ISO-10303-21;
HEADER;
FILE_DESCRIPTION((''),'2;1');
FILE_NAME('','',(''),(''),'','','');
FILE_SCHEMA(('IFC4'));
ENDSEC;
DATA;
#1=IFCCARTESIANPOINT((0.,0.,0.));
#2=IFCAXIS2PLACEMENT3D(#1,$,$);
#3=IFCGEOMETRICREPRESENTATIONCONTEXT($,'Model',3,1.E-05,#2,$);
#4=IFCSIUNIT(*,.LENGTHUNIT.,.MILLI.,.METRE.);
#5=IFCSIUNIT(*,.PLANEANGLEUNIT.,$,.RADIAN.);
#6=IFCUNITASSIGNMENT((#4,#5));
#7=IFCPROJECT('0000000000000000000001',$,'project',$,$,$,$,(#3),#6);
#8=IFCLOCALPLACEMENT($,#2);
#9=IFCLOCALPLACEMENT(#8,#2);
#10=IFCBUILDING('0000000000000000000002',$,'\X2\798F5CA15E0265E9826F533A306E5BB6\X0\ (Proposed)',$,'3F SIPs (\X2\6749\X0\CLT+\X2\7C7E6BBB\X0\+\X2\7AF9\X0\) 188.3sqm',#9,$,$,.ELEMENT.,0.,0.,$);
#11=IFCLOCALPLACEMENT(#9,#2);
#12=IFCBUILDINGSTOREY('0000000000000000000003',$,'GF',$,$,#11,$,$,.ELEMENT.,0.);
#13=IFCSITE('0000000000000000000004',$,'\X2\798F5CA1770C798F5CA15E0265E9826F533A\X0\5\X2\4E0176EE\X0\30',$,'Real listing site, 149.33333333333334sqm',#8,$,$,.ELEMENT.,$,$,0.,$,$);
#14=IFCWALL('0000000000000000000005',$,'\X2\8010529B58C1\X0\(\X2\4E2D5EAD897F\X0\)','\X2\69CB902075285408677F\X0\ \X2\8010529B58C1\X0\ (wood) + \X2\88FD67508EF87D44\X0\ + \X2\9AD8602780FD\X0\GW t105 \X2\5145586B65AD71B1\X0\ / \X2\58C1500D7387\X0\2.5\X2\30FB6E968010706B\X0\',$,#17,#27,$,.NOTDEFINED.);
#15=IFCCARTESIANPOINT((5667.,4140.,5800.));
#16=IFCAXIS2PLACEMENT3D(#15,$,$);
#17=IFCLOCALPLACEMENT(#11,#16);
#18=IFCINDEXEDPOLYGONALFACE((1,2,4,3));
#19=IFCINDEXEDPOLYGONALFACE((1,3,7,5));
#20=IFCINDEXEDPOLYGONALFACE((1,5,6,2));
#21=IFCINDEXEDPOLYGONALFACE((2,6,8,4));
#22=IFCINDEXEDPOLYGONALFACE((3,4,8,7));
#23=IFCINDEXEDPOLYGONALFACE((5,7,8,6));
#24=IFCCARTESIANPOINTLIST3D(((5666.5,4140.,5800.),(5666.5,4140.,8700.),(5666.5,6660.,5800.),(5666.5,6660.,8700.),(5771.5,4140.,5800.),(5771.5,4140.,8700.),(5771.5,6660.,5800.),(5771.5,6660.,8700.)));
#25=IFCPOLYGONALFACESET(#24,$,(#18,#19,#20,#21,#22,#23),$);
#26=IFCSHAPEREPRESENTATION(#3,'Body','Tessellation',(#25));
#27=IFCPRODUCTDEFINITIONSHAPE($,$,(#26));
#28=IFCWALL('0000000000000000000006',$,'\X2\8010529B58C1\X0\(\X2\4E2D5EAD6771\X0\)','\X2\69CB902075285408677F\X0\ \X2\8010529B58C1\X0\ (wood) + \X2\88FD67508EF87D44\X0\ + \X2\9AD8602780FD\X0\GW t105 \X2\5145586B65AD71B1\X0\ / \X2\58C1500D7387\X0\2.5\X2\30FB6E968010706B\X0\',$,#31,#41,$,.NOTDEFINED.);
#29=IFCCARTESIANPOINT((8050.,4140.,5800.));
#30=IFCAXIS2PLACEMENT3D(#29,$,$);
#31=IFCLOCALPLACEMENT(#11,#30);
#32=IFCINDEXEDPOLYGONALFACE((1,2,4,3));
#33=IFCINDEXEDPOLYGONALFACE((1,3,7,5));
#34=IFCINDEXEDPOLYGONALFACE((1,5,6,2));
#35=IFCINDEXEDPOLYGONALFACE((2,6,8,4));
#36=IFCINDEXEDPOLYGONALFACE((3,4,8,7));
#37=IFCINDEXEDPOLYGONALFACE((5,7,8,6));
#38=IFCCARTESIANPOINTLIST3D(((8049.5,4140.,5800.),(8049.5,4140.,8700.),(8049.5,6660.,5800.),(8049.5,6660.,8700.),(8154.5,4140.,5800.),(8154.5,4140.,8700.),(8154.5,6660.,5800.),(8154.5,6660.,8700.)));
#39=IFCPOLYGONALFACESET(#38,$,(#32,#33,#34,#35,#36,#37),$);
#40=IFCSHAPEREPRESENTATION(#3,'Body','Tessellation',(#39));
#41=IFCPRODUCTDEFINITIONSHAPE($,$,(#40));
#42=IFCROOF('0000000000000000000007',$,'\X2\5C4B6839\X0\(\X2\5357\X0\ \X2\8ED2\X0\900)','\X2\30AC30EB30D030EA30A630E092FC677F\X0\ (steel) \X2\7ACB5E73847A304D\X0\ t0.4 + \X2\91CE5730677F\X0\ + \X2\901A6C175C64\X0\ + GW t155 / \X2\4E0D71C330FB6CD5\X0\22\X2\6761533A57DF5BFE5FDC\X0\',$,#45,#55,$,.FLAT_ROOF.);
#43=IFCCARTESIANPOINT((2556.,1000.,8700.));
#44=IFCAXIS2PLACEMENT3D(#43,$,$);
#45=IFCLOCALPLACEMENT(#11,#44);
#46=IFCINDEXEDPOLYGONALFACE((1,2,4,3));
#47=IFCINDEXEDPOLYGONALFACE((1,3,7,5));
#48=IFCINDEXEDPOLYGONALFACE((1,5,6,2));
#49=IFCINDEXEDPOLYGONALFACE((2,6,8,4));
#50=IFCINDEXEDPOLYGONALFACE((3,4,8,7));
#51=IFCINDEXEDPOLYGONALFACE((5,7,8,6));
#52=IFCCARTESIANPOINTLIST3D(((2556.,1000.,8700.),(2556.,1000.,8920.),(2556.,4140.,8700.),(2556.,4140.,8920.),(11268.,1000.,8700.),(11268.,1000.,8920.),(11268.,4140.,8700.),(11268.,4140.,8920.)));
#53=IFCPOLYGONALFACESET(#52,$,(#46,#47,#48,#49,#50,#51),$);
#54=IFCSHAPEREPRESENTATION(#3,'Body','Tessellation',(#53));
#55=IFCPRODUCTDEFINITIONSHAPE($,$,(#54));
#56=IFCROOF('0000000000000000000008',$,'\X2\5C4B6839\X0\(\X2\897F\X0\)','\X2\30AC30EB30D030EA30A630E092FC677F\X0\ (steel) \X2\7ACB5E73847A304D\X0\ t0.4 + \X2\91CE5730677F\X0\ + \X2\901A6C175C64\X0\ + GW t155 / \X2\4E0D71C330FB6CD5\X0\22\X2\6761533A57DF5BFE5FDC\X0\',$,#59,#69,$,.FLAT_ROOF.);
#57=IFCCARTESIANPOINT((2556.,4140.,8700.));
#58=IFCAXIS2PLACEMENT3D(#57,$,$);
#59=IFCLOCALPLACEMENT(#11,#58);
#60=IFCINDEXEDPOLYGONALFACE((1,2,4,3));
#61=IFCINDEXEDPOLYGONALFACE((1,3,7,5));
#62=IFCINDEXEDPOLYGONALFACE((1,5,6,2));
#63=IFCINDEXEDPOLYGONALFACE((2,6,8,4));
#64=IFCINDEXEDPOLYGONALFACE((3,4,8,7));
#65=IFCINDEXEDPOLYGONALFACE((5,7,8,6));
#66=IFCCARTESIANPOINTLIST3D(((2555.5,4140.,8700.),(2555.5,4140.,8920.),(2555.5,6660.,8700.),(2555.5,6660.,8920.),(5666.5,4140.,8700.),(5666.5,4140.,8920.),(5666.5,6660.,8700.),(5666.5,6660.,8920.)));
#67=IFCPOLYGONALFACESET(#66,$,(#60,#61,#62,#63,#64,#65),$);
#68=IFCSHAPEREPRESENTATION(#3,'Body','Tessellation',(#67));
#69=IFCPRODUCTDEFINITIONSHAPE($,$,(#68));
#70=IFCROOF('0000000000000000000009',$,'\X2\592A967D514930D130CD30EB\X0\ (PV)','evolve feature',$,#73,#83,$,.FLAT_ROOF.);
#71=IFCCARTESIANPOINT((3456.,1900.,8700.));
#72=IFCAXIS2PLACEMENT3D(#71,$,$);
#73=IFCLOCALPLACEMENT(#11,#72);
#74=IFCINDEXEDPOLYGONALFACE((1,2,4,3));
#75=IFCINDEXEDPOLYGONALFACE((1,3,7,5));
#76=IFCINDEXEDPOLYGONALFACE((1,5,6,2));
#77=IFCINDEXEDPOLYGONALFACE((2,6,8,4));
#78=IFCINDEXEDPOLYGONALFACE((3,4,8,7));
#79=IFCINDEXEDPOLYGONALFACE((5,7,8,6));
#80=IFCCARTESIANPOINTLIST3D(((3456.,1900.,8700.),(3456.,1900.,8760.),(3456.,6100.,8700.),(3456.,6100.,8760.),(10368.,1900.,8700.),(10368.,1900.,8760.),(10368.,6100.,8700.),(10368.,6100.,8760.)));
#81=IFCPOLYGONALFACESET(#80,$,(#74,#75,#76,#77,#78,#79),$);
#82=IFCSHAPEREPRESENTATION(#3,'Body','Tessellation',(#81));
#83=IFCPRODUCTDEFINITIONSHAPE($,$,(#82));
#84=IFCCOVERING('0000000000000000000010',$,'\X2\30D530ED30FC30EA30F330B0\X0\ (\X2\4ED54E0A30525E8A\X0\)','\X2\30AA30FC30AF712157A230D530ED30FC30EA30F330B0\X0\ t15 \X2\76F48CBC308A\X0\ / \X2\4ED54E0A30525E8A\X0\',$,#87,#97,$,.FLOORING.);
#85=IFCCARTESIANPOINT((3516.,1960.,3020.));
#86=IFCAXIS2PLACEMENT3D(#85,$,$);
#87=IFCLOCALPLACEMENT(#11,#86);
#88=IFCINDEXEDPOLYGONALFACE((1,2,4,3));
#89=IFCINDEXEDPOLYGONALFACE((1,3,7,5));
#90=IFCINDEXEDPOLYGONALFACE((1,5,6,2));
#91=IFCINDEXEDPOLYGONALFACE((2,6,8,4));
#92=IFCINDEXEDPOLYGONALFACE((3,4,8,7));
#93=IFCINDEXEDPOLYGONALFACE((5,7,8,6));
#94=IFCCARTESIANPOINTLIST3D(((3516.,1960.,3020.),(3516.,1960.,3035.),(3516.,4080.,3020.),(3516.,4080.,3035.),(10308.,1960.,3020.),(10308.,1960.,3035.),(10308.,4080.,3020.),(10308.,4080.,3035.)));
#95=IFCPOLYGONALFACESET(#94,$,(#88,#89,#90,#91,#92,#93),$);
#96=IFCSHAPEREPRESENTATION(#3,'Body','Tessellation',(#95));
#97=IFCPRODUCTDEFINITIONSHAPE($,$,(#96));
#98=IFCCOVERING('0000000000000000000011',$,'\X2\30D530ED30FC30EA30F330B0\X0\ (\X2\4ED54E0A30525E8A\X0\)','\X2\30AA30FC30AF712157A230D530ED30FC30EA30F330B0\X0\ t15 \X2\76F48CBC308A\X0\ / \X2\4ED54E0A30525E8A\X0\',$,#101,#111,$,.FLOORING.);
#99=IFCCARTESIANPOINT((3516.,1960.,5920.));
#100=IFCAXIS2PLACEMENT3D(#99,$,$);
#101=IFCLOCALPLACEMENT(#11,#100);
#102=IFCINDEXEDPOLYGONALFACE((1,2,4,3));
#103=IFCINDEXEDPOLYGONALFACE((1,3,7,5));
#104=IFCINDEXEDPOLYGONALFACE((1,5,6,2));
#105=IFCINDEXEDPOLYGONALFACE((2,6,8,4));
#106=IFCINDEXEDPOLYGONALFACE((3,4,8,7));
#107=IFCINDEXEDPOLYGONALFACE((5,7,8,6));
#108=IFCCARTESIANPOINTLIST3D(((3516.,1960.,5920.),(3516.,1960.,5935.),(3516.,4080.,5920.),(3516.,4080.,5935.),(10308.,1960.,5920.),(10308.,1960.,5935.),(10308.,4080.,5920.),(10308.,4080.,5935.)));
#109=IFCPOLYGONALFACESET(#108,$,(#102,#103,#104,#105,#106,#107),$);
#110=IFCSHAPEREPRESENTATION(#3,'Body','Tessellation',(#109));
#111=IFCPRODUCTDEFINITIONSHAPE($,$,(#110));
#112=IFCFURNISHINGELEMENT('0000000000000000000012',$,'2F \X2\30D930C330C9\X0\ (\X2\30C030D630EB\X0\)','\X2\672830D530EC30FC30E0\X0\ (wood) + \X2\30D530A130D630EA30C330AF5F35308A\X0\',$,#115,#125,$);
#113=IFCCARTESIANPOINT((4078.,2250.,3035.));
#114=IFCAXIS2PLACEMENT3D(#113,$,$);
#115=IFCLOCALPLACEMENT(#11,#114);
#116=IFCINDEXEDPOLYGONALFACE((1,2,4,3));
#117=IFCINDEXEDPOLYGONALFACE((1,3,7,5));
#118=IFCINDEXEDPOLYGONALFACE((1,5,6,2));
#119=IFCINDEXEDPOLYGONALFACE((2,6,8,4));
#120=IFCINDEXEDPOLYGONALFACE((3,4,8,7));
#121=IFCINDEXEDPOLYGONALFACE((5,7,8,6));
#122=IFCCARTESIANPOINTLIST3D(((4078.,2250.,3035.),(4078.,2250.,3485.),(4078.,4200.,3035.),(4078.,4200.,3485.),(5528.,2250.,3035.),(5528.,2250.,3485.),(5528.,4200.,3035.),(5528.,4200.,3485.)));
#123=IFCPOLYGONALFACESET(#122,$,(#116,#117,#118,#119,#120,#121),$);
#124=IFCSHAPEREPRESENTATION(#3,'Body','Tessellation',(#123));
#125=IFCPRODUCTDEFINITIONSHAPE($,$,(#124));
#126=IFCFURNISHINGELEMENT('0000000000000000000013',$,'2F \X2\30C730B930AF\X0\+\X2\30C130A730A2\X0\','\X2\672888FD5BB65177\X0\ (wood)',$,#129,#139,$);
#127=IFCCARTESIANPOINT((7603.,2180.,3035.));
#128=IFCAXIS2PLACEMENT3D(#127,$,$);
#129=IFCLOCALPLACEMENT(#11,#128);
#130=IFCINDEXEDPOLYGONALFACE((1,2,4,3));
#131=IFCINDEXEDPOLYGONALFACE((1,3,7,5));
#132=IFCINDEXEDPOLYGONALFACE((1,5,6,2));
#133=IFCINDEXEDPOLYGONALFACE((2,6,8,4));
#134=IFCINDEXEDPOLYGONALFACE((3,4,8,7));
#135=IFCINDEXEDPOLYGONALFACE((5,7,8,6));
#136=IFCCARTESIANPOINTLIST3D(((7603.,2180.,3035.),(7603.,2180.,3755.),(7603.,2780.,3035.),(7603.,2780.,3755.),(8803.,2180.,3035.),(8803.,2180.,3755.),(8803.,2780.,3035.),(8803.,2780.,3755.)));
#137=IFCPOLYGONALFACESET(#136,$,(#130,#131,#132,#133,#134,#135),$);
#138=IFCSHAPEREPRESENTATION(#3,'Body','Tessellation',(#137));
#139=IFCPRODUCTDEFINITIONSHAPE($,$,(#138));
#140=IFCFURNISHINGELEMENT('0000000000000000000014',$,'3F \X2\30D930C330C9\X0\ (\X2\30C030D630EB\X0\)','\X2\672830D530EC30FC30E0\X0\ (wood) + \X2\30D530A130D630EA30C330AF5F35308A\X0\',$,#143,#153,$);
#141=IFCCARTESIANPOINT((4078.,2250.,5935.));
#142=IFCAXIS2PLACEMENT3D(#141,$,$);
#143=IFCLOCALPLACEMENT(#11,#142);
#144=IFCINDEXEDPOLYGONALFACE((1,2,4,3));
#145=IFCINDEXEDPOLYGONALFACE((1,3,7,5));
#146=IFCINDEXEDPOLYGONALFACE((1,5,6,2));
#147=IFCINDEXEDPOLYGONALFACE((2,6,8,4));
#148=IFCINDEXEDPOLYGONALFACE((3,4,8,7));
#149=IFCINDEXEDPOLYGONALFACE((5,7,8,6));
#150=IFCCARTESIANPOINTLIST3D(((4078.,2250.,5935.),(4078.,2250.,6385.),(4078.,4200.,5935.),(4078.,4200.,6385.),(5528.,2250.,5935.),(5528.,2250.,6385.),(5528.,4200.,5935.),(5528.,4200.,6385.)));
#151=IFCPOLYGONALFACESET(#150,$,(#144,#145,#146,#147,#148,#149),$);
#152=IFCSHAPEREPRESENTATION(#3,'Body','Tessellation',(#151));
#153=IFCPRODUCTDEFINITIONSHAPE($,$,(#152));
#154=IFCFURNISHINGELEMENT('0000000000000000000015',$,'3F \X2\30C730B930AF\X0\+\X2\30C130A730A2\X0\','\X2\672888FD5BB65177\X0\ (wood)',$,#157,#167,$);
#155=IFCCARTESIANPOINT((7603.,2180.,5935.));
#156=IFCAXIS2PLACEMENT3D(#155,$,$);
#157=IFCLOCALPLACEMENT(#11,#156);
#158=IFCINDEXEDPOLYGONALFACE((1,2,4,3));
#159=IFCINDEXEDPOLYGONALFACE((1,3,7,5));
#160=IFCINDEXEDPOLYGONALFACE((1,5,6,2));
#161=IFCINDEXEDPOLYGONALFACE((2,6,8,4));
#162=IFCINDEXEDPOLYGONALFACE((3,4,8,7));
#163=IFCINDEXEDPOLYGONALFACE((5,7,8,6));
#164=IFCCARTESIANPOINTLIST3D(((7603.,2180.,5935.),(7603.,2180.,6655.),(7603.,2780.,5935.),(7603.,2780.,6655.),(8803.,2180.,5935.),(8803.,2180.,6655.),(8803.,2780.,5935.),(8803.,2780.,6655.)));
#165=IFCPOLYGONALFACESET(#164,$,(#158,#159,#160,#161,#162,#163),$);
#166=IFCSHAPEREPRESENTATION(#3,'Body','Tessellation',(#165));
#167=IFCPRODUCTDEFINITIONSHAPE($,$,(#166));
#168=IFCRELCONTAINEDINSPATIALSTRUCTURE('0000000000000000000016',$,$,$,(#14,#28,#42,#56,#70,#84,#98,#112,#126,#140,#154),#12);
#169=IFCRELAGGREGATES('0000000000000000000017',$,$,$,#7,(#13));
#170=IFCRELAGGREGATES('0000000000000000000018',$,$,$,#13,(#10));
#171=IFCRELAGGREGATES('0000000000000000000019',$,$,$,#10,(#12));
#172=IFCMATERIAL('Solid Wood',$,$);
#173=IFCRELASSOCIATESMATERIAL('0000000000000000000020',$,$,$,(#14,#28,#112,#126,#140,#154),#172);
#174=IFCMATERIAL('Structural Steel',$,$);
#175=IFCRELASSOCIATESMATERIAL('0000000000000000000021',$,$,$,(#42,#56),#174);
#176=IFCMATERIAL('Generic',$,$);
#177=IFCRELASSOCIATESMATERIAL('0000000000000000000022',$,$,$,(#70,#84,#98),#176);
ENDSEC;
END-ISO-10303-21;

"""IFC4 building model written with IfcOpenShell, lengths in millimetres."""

from ifc_helpers import new_model, si_unit, frame, frame_2d, origin, place, context, project, spatial, rectangle, extrude, material, element, save


model = new_model("IFC4")

# Units and contexts
model_context = context("Model", 3, precision=1e-05, world=origin())
ifc_project = project(units=[si_unit("LENGTHUNIT", "METRE", prefix="MILLI"), si_unit("PLANEANGLEUNIT", "RADIAN")], contexts=[model_context])

# Site, building, storey
site_placement = place(None, origin())
site = spatial("IfcSite", under=ifc_project, at=site_placement, Name="福岡県福岡市早良区5丁目30", ObjectType="Real listing site, 149.33333333333334sqm", CompositionType="ELEMENT", RefElevation=0.0)
building_placement = place(site_placement, origin())
building = spatial("IfcBuilding", under=site, at=building_placement, Name="福岡市早良区の家 (Proposed)", ObjectType="3F SIPs (杉CLT+籾殻+竹) 188.3sqm", CompositionType="ELEMENT", ElevationOfRefHeight=0.0, ElevationOfTerrain=0.0)
storey_placement = place(building_placement, origin())
storey = spatial("IfcBuildingStorey", under=building, at=storey_placement, Name="GF", CompositionType="ELEMENT", Elevation=0.0)

# Shared definitions
ifc_material_1 = material(Name="Solid Wood")

# Walls
wall_1_placement = place(storey_placement, frame((5667.0, 4140.0, 5800.0)))
element("IfcWall", 1, at=wall_1_placement, inside=storey, material=ifc_material_1, Name="耐力壁(中庭西)", Description="構造用合板 耐力壁 (wood) + 製材軸組 + 高性能GW t105 充填断熱 / 壁倍率2.5・準耐火", PredefinedType="NOTDEFINED", context=model_context, shape_type="SweptSolid", body=[
    extrude(rectangle(XDim=105.0, YDim=2520.0, at=frame_2d((52.0, 1260.0))), frame((5667.0, 4140.0, 5800.0)), (0.0, 0.0, 1.0), 2900.0),
])
wall_2_placement = place(storey_placement, frame((8050.0, 4140.0, 5800.0)))
element("IfcWall", 2, at=wall_2_placement, inside=storey, material=ifc_material_1, Name="耐力壁(中庭東)", Description="構造用合板 耐力壁 (wood) + 製材軸組 + 高性能GW t105 充填断熱 / 壁倍率2.5・準耐火", PredefinedType="NOTDEFINED", context=model_context, shape_type="SweptSolid", body=[
    extrude(rectangle(XDim=105.0, YDim=2520.0, at=frame_2d((52.0, 1260.0))), frame((8050.0, 4140.0, 5800.0)), (0.0, 0.0, 1.0), 2900.0),
])

# Roofs
ifc_material_2 = material(Name="Structural Steel")
roof_1_placement = place(storey_placement, frame((2556.0, 1000.0, 8700.0)))
element("IfcRoof", 3, at=roof_1_placement, inside=storey, material=ifc_material_2, Name="屋根(南 軒900)", Description="ガルバリウム鋼板 (steel) 立平葺き t0.4 + 野地板 + 通気層 + GW t155 / 不燃・法22条区域対応", PredefinedType="FLAT_ROOF", context=model_context, shape_type="SweptSolid", body=[
    extrude(rectangle(XDim=8712.0, YDim=3140.0, at=frame_2d((4356.0, 1570.0))), frame((2556.0, 1000.0, 8700.0)), (0.0, 0.0, 1.0), 220.0),
])
roof_2_placement = place(storey_placement, frame((2556.0, 4140.0, 8700.0)))
element("IfcRoof", 4, at=roof_2_placement, inside=storey, material=ifc_material_2, Name="屋根(西)", Description="ガルバリウム鋼板 (steel) 立平葺き t0.4 + 野地板 + 通気層 + GW t155 / 不燃・法22条区域対応", PredefinedType="FLAT_ROOF", context=model_context, shape_type="SweptSolid", body=[
    extrude(rectangle(XDim=3111.0, YDim=2520.0, at=frame_2d((1555.0, 1260.0))), frame((2556.0, 4140.0, 8700.0)), (0.0, 0.0, 1.0), 220.0),
])
ifc_material_3 = material(Name="Generic")
roof_3_placement = place(storey_placement, frame((3456.0, 1900.0, 8700.0)))
element("IfcRoof", 5, at=roof_3_placement, inside=storey, material=ifc_material_3, Name="太陽光パネル (PV)", Description="evolve feature", PredefinedType="FLAT_ROOF", context=model_context, shape_type="SweptSolid", body=[
    extrude(rectangle(XDim=6912.0, YDim=4200.0, at=frame_2d((3456.0, 2100.0))), frame((3456.0, 1900.0, 8700.0)), (0.0, 0.0, 1.0), 60.0),
])

# Coverings
covering_1_placement = place(storey_placement, frame((3516.0, 1960.0, 3020.0)))
element("IfcCovering", 6, at=covering_1_placement, inside=storey, material=ifc_material_3, Name="フローリング (仕上げ床)", Description="オーク無垢フローリング t15 直貼り / 仕上げ床", PredefinedType="FLOORING", context=model_context, shape_type="SweptSolid", body=[
    extrude(rectangle(XDim=6792.0, YDim=2120.0, at=frame_2d((3396.0, 1060.0))), frame((3516.0, 1960.0, 3020.0)), (0.0, 0.0, 1.0), 15.0),
])
covering_2_placement = place(storey_placement, frame((3516.0, 1960.0, 5920.0)))
element("IfcCovering", 7, at=covering_2_placement, inside=storey, material=ifc_material_3, Name="フローリング (仕上げ床)", Description="オーク無垢フローリング t15 直貼り / 仕上げ床", PredefinedType="FLOORING", context=model_context, shape_type="SweptSolid", body=[
    extrude(rectangle(XDim=6792.0, YDim=2120.0, at=frame_2d((3396.0, 1060.0))), frame((3516.0, 1960.0, 5920.0)), (0.0, 0.0, 1.0), 15.0),
])

# Furnishing elements
furnishing_1_placement = place(storey_placement, frame((4078.0, 2250.0, 3035.0)))
element("IfcFurnishingElement", 8, at=furnishing_1_placement, inside=storey, material=ifc_material_1, Name="2F ベッド (ダブル)", Description="木フレーム (wood) + ファブリック張り", context=model_context, shape_type="SweptSolid", body=[
    extrude(rectangle(XDim=1450.0, YDim=1950.0, at=frame_2d((725.0, 975.0))), frame((4078.0, 2250.0, 3035.0)), (0.0, 0.0, 1.0), 450.0),
])
furnishing_2_placement = place(storey_placement, frame((7603.0, 2180.0, 3035.0)))
element("IfcFurnishingElement", 9, at=furnishing_2_placement, inside=storey, material=ifc_material_1, Name="2F デスク+チェア", Description="木製家具 (wood)", context=model_context, shape_type="SweptSolid", body=[
    extrude(rectangle(XDim=1200.0, YDim=600.0, at=frame_2d((600.0, 300.0))), frame((7603.0, 2180.0, 3035.0)), (0.0, 0.0, 1.0), 720.0),
])
furnishing_3_placement = place(storey_placement, frame((4078.0, 2250.0, 5935.0)))
element("IfcFurnishingElement", 10, at=furnishing_3_placement, inside=storey, material=ifc_material_1, Name="3F ベッド (ダブル)", Description="木フレーム (wood) + ファブリック張り", context=model_context, shape_type="SweptSolid", body=[
    extrude(rectangle(XDim=1450.0, YDim=1950.0, at=frame_2d((725.0, 975.0))), frame((4078.0, 2250.0, 5935.0)), (0.0, 0.0, 1.0), 450.0),
])
furnishing_4_placement = place(storey_placement, frame((7603.0, 2180.0, 5935.0)))
element("IfcFurnishingElement", 11, at=furnishing_4_placement, inside=storey, material=ifc_material_1, Name="3F デスク+チェア", Description="木製家具 (wood)", context=model_context, shape_type="SweptSolid", body=[
    extrude(rectangle(XDim=1200.0, YDim=600.0, at=frame_2d((600.0, 300.0))), frame((7603.0, 2180.0, 5935.0)), (0.0, 0.0, 1.0), 720.0),
])

save(model, "model.ifc")
